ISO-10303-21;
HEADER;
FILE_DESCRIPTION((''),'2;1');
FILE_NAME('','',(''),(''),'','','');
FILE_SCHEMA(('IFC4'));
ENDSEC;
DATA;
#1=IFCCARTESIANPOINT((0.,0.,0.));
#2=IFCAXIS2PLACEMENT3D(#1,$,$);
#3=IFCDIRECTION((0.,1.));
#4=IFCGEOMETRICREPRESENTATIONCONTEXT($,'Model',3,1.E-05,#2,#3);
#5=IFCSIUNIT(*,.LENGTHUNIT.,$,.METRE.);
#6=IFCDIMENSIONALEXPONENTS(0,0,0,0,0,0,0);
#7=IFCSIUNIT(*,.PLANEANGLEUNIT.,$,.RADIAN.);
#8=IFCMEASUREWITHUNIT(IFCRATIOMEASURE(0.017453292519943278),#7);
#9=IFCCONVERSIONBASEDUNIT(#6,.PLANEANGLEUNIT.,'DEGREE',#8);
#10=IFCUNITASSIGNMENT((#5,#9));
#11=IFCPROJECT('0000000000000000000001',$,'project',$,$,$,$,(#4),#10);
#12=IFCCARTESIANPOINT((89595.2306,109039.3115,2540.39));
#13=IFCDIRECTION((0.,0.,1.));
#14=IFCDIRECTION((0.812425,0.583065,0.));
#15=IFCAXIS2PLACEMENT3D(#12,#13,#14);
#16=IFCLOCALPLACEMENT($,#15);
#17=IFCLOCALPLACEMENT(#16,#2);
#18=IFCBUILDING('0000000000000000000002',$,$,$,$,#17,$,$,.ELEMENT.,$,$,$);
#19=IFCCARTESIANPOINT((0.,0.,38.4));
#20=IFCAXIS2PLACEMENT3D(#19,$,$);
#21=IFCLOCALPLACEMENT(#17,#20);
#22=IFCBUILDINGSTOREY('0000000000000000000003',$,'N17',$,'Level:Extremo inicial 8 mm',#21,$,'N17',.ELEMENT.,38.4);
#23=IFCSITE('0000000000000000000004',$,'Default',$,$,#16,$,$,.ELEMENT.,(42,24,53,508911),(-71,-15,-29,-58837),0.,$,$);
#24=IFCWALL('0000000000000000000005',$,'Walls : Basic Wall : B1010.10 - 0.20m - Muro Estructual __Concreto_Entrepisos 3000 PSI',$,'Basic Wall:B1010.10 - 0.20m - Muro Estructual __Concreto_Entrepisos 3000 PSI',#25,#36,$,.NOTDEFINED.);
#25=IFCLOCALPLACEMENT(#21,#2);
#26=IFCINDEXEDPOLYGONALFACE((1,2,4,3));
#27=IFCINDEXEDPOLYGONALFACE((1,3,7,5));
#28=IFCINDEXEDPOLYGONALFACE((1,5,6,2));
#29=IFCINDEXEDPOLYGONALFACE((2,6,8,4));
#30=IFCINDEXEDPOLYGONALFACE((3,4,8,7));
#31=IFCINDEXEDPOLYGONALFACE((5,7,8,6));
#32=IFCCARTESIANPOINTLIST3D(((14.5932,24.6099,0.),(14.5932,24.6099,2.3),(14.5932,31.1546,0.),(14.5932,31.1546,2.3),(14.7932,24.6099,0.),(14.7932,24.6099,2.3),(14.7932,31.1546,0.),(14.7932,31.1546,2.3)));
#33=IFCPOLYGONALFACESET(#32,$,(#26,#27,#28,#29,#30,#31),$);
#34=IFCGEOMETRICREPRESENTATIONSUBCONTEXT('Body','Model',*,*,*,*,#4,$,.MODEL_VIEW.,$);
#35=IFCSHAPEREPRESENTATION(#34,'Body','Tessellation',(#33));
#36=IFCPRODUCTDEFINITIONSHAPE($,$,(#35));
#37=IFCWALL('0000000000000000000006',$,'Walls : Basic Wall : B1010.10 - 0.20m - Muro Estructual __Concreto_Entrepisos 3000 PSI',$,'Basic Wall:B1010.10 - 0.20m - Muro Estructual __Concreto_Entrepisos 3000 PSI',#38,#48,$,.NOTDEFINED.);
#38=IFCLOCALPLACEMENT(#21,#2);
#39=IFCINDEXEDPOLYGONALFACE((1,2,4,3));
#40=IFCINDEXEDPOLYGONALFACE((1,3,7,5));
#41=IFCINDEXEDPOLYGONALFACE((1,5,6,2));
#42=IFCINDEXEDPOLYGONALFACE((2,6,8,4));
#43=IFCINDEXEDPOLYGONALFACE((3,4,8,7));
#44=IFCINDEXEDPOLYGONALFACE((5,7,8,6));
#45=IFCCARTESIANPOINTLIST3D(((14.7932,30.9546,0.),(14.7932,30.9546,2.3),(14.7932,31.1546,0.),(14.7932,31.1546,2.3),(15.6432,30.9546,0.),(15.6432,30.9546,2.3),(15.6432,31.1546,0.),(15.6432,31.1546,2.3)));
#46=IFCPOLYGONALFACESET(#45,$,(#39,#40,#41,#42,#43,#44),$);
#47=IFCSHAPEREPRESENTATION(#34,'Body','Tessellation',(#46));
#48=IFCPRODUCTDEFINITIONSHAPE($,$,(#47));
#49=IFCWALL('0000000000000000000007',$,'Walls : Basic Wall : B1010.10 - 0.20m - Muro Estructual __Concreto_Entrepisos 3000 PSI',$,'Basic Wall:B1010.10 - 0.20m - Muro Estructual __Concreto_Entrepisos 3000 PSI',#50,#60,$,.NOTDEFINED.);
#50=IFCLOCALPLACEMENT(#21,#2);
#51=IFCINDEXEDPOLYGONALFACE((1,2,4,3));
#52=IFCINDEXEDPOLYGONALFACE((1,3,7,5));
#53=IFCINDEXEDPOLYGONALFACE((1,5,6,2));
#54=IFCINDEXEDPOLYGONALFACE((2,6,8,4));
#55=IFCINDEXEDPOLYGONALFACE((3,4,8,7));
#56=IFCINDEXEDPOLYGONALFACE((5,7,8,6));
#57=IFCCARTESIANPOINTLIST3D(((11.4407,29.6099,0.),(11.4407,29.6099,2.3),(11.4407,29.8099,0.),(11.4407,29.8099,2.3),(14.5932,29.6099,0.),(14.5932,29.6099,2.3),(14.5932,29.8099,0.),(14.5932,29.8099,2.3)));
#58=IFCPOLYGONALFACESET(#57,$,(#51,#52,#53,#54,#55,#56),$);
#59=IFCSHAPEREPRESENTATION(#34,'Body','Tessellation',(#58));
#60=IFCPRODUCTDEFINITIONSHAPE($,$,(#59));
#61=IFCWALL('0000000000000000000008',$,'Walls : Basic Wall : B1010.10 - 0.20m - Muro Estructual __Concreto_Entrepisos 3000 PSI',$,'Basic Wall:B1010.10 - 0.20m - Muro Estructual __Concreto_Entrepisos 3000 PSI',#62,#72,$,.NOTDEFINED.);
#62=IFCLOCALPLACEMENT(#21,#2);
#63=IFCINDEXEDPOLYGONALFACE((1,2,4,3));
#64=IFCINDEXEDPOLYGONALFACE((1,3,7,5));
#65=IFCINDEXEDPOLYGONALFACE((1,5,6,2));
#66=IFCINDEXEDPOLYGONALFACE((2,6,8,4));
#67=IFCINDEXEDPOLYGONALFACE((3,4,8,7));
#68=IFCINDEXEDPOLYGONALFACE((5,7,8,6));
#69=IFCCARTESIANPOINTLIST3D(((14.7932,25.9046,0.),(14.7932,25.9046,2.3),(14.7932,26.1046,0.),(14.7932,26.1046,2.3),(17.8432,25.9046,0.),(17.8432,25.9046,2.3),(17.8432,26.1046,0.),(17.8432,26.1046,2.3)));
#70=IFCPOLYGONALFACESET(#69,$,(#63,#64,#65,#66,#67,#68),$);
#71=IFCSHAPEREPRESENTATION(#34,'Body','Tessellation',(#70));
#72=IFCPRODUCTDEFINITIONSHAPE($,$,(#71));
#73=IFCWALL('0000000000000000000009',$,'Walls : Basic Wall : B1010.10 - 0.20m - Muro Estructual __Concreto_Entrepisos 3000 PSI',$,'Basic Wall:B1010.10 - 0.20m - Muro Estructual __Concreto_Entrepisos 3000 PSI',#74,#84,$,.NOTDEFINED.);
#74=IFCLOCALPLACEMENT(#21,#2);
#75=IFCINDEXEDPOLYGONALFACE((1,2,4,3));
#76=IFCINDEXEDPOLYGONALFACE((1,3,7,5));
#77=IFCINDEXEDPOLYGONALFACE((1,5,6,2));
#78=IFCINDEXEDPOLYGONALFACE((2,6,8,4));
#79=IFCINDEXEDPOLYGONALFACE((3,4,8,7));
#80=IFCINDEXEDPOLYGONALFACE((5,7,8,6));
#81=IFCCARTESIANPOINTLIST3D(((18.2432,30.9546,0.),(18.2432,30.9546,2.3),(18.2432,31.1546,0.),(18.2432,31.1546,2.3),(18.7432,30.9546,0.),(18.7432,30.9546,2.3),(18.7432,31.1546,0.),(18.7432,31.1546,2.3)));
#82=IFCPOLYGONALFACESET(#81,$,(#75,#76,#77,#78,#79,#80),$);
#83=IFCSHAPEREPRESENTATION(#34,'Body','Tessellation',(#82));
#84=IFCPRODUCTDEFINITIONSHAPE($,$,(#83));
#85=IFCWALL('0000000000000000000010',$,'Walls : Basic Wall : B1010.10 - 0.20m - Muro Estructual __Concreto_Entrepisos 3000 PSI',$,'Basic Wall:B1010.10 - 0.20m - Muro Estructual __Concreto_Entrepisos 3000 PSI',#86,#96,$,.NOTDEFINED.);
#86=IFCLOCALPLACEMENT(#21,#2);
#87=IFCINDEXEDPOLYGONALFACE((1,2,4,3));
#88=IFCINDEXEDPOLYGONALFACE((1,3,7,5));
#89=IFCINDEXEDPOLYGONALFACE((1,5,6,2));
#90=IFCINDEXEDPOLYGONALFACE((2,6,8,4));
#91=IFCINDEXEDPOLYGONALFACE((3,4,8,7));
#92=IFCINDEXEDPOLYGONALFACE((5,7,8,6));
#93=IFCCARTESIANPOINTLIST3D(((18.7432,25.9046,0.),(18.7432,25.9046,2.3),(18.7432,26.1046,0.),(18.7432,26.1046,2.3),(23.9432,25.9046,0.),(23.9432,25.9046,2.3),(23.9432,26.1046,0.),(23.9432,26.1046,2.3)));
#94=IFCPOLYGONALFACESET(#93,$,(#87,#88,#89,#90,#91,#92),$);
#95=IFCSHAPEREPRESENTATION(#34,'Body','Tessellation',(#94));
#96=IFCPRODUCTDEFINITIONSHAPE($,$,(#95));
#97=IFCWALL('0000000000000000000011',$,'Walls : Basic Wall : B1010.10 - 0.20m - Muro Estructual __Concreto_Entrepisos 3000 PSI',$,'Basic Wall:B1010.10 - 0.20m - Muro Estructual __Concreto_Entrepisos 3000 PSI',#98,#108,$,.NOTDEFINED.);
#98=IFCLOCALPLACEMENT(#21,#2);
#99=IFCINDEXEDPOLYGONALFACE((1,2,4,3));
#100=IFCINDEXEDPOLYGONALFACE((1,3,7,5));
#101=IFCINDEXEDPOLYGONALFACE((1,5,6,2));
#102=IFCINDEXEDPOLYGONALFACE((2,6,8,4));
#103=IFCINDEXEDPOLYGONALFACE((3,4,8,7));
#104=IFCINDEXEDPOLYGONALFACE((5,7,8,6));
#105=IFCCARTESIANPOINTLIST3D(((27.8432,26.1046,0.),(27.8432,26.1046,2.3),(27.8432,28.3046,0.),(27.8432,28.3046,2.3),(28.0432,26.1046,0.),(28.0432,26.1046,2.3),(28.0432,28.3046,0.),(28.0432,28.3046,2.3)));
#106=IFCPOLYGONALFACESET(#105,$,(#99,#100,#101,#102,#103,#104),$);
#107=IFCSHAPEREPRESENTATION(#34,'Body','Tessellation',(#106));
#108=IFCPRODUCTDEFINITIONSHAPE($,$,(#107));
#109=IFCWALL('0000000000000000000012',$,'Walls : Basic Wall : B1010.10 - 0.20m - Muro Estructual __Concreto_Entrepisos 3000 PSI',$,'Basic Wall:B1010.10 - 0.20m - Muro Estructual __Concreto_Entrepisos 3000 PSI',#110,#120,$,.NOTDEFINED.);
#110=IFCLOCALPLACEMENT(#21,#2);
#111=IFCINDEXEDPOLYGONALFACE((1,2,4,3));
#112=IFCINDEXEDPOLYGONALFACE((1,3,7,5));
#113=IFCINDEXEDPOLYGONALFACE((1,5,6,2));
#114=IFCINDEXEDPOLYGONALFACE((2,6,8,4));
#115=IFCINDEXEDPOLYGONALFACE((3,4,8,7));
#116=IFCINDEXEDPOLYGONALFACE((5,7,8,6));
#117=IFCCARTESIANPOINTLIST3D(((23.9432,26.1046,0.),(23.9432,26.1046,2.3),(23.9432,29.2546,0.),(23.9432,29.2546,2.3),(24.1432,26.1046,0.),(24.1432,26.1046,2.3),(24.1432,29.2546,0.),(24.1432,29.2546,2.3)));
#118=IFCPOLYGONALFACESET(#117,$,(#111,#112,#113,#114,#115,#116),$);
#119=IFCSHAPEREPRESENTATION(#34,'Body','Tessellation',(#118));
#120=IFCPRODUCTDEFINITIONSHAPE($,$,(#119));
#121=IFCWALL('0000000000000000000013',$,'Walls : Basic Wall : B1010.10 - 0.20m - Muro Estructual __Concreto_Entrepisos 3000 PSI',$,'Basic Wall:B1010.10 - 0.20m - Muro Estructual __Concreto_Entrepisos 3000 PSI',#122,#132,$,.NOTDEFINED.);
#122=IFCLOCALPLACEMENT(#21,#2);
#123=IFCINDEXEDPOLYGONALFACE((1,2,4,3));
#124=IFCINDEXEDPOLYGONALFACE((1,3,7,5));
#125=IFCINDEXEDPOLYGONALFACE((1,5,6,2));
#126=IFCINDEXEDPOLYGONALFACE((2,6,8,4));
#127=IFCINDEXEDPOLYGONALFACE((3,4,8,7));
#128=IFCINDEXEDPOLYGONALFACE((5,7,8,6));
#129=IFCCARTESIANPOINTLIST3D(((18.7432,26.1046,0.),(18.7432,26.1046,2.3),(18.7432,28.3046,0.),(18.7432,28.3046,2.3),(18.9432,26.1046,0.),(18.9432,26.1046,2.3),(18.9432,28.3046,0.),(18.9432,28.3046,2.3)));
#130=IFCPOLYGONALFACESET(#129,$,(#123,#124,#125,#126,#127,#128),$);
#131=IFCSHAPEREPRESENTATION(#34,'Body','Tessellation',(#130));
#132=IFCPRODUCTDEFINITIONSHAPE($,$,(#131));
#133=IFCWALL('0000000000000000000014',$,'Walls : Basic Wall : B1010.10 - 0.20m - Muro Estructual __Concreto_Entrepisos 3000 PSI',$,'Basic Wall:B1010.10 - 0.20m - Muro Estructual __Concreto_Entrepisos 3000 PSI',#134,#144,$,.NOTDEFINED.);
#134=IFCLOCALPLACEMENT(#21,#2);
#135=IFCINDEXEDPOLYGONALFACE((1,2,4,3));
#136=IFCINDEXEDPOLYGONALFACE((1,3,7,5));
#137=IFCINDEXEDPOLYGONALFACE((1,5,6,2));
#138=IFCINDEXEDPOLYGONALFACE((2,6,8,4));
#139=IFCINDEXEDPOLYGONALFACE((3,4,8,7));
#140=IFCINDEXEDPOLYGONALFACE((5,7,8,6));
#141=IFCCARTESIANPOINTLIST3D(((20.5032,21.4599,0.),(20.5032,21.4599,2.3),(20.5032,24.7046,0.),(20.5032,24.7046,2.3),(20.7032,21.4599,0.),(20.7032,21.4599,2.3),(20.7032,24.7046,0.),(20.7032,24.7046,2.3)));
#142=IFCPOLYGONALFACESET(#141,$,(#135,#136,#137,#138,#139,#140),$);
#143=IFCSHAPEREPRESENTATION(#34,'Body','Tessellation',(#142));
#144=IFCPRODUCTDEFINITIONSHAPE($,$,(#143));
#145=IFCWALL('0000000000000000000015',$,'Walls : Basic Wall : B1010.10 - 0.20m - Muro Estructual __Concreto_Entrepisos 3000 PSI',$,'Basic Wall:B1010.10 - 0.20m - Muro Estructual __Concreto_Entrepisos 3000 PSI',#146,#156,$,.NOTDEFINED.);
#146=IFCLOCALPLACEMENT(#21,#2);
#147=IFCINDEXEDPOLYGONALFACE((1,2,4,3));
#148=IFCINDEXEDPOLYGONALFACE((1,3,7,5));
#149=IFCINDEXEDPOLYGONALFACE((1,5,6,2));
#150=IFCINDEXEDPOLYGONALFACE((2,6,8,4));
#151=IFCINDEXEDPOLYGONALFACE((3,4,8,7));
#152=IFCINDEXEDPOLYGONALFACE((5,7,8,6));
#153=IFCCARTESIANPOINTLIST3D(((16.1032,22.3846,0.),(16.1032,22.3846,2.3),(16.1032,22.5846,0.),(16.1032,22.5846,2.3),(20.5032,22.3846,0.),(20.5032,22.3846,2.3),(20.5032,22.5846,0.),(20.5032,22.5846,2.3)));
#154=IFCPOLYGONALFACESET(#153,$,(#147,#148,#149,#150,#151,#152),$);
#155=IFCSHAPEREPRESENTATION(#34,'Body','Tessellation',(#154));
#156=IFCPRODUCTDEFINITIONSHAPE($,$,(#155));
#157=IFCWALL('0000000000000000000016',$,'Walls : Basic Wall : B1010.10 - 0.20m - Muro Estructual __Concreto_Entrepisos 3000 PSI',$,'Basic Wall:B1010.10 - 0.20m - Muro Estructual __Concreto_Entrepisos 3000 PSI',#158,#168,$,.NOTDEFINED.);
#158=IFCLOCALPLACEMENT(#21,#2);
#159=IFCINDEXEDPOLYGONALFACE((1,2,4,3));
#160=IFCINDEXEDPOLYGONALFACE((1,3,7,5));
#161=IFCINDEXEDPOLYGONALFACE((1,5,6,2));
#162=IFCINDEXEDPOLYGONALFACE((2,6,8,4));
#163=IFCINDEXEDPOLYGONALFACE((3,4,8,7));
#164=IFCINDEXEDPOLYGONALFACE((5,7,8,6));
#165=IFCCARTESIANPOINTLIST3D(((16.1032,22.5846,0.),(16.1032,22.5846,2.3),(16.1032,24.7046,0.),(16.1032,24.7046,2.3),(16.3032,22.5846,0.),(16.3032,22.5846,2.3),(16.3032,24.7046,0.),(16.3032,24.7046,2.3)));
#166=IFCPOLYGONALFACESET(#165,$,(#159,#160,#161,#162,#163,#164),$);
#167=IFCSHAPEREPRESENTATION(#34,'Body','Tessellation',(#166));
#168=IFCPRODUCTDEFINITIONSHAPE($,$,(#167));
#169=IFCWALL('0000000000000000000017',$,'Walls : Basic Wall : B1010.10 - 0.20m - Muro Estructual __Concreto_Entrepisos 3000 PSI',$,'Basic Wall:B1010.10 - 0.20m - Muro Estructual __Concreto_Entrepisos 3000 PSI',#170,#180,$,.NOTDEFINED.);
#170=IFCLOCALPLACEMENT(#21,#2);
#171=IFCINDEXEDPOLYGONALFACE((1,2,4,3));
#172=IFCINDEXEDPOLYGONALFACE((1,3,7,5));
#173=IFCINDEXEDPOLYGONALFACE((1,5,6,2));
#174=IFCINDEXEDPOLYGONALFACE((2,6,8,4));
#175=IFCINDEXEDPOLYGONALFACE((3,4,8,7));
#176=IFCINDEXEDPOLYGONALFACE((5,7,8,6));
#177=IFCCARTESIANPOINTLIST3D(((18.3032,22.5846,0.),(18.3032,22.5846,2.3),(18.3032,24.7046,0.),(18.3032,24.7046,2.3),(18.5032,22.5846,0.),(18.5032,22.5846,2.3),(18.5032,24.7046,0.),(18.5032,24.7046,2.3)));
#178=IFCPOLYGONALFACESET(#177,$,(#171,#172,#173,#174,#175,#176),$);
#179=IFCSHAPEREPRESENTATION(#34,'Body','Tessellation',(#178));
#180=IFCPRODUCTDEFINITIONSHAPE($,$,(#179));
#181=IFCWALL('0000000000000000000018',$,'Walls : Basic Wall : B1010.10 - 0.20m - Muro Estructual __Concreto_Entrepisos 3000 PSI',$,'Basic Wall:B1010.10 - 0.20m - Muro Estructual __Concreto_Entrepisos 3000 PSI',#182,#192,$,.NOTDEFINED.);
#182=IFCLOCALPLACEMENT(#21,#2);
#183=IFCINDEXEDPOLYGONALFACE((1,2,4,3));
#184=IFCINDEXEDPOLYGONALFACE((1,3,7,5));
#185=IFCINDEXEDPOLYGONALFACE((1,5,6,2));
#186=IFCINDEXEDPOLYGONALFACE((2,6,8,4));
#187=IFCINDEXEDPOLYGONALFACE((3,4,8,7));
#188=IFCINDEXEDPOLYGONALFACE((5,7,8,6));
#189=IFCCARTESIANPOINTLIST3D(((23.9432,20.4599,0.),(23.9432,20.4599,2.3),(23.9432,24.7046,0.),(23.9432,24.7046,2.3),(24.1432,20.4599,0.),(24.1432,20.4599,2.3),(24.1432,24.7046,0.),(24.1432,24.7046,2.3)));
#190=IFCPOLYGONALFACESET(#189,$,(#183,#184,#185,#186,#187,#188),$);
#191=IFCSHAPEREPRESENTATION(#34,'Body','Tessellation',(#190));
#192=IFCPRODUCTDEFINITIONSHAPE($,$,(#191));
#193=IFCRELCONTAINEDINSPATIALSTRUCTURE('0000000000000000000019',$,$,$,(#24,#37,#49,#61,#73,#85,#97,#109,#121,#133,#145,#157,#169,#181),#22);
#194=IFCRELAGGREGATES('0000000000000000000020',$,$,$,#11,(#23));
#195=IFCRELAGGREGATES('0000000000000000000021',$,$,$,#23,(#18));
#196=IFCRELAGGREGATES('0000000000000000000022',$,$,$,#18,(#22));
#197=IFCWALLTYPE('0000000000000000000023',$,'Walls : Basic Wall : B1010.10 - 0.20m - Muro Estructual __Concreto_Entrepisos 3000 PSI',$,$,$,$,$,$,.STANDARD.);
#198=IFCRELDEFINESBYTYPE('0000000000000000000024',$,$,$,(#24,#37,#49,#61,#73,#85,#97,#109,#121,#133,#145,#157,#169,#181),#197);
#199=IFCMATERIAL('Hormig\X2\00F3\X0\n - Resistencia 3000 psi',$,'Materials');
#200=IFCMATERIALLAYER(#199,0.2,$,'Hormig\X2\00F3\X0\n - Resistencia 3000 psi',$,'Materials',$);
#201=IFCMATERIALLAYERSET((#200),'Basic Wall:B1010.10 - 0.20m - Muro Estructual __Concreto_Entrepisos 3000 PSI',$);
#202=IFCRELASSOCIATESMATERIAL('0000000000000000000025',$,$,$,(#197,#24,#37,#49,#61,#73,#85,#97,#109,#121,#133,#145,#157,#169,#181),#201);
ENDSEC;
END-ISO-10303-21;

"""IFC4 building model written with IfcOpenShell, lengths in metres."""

from ifc_helpers import new_model, entity, si_unit, converted_unit, direction, frame, frame_2d, origin, place, context, subcontext, project, spatial, rectangle, extrude, material, layer, layer_set, layer_usage, type_object, element, save


model = new_model("IFC4")

# Units and contexts
model_context = context("Model", 3, precision=1e-05, world=origin(), true_north=direction((0.0, 1.0)))
body_context = subcontext(model_context, "Body", "Model", "MODEL_VIEW")
ifc_project = project(units=[si_unit("LENGTHUNIT", "METRE"), converted_unit("PLANEANGLEUNIT", "DEGREE", entity("IfcRatioMeasure", 0.017453292519943278), si_unit("PLANEANGLEUNIT", "RADIAN"), dimensions=[0, 0, 0, 0, 0, 0, 0])], contexts=[model_context])

# Site, building, storey
site_placement = place(None, frame((89595.2306, 109039.3115, 2540.39), z_axis=(0.0, 0.0, 1.0), x_axis=(0.812425, 0.583065, 0.0)))
site = spatial("IfcSite", under=ifc_project, at=site_placement, Name="Default", CompositionType="ELEMENT", RefLatitude=(42, 24, 53, 508911), RefLongitude=(-71, -15, -29, -58837), RefElevation=0.0)
building_placement = place(site_placement, origin())
building = spatial("IfcBuilding", under=site, at=building_placement, CompositionType="ELEMENT")
storey_placement = place(building_placement, frame((0.0, 0.0, 38.4)))
storey = spatial("IfcBuildingStorey", under=building, at=storey_placement, Name="N17", ObjectType="Level:Extremo inicial 8 mm", LongName="N17", CompositionType="ELEMENT", Elevation=38.4)

# Walls
ifc_material_1 = material(Name="Hormigón - Resistencia 3000 psi", Category="Materials")
ifc_layer_1 = layer(ifc_material_1, 0.2, Name="Hormigón - Resistencia 3000 psi", Category="Materials")
ifc_layer_set_1 = layer_set([ifc_layer_1], Name="Basic Wall:B1010.10 - 0.20m - Muro Estructual __Concreto_Entrepisos 3000 PSI")
ifc_layer_usage_1 = layer_usage(ifc_layer_set_1, "AXIS2", "NEGATIVE", 0.1)
wall_type_1 = type_object("IfcWallType", Name="Walls : Basic Wall : B1010.10 - 0.20m - Muro Estructual __Concreto_Entrepisos 3000 PSI", PredefinedType="STANDARD", material=ifc_layer_set_1)
wall_1_placement = place(storey_placement, frame((14.6932, 24.6099, 0.0), z_axis=(0.0, 0.0, 1.0), x_axis=(0.0, 1.0, 0.0)))
element("IfcWall", 1, at=wall_1_placement, inside=storey, type_object=wall_type_1, material=ifc_layer_usage_1, Name="Walls : Basic Wall : B1010.10 - 0.20m - Muro Estructual __Concreto_Entrepisos 3000 PSI", ObjectType="Basic Wall:B1010.10 - 0.20m - Muro Estructual __Concreto_Entrepisos 3000 PSI", PredefinedType="NOTDEFINED", context=body_context, shape_type="SweptSolid", body=[
    extrude(rectangle(XDim=6.5447, YDim=0.2, at=frame_2d((3.2724, 0.0), x_axis=(-1.0, 0.0))), origin(), (0.0, 0.0, 1.0), 2.3),
])
ifc_layer_usage_2 = layer_usage(ifc_layer_set_1, "AXIS2", "NEGATIVE", 0.1)
wall_2_placement = place(storey_placement, frame((15.6432, 31.0546, 0.0), z_axis=(0.0, 0.0, 1.0), x_axis=(-1.0, 0.0, 0.0)))
element("IfcWall", 2, at=wall_2_placement, inside=storey, type_object=wall_type_1, material=ifc_layer_usage_2, Name="Walls : Basic Wall : B1010.10 - 0.20m - Muro Estructual __Concreto_Entrepisos 3000 PSI", ObjectType="Basic Wall:B1010.10 - 0.20m - Muro Estructual __Concreto_Entrepisos 3000 PSI", PredefinedType="NOTDEFINED", context=body_context, shape_type="SweptSolid", body=[
    extrude(rectangle(XDim=0.85, YDim=0.2, at=frame_2d((0.425, 0.0), x_axis=(-1.0, 0.0))), origin(), (0.0, 0.0, 1.0), 2.3),
])
ifc_layer_usage_3 = layer_usage(ifc_layer_set_1, "AXIS2", "NEGATIVE", 0.1)
wall_3_placement = place(storey_placement, frame((11.4407, 29.7099, 0.0)))
element("IfcWall", 3, at=wall_3_placement, inside=storey, type_object=wall_type_1, material=ifc_layer_usage_3, Name="Walls : Basic Wall : B1010.10 - 0.20m - Muro Estructual __Concreto_Entrepisos 3000 PSI", ObjectType="Basic Wall:B1010.10 - 0.20m - Muro Estructual __Concreto_Entrepisos 3000 PSI", PredefinedType="NOTDEFINED", context=body_context, shape_type="SweptSolid", body=[
    extrude(rectangle(XDim=3.1525, YDim=0.2, at=frame_2d((1.5763, 0.0), x_axis=(-1.0, 0.0))), origin(), (0.0, 0.0, 1.0), 2.3),
])
ifc_layer_usage_4 = layer_usage(ifc_layer_set_1, "AXIS2", "NEGATIVE", 0.1)
wall_4_placement = place(storey_placement, frame((17.8432, 26.0046, 0.0), z_axis=(0.0, 0.0, 1.0), x_axis=(-1.0, 0.0, 0.0)))
element("IfcWall", 4, at=wall_4_placement, inside=storey, type_object=wall_type_1, material=ifc_layer_usage_4, Name="Walls : Basic Wall : B1010.10 - 0.20m - Muro Estructual __Concreto_Entrepisos 3000 PSI", ObjectType="Basic Wall:B1010.10 - 0.20m - Muro Estructual __Concreto_Entrepisos 3000 PSI", PredefinedType="NOTDEFINED", context=body_context, shape_type="SweptSolid", body=[
    extrude(rectangle(XDim=3.05, YDim=0.2, at=frame_2d((1.525, 0.0), x_axis=(-1.0, 0.0))), origin(), (0.0, 0.0, 1.0), 2.3),
])
ifc_layer_usage_5 = layer_usage(ifc_layer_set_1, "AXIS2", "NEGATIVE", 0.1)
wall_5_placement = place(storey_placement, frame((18.7432, 31.0546, 0.0), z_axis=(0.0, 0.0, 1.0), x_axis=(-1.0, 0.0, 0.0)))
element("IfcWall", 5, at=wall_5_placement, inside=storey, type_object=wall_type_1, material=ifc_layer_usage_5, Name="Walls : Basic Wall : B1010.10 - 0.20m - Muro Estructual __Concreto_Entrepisos 3000 PSI", ObjectType="Basic Wall:B1010.10 - 0.20m - Muro Estructual __Concreto_Entrepisos 3000 PSI", PredefinedType="NOTDEFINED", context=body_context, shape_type="SweptSolid", body=[
    extrude(rectangle(XDim=0.5, YDim=0.2, at=frame_2d((0.25, 0.0), x_axis=(-1.0, 0.0))), origin(), (0.0, 0.0, 1.0), 2.3),
])
ifc_layer_usage_6 = layer_usage(ifc_layer_set_1, "AXIS2", "NEGATIVE", 0.1)
wall_6_placement = place(storey_placement, frame((18.7432, 26.0046, 0.0)))
element("IfcWall", 6, at=wall_6_placement, inside=storey, type_object=wall_type_1, material=ifc_layer_usage_6, Name="Walls : Basic Wall : B1010.10 - 0.20m - Muro Estructual __Concreto_Entrepisos 3000 PSI", ObjectType="Basic Wall:B1010.10 - 0.20m - Muro Estructual __Concreto_Entrepisos 3000 PSI", PredefinedType="NOTDEFINED", context=body_context, shape_type="SweptSolid", body=[
    extrude(rectangle(XDim=5.2, YDim=0.2, at=frame_2d((2.6, 0.0), x_axis=(-1.0, 0.0))), origin(), (0.0, 0.0, 1.0), 2.3),
])
ifc_layer_usage_7 = layer_usage(ifc_layer_set_1, "AXIS2", "NEGATIVE", 0.1)
wall_7_placement = place(storey_placement, frame((27.9432, 28.3046, 0.0), z_axis=(0.0, 0.0, 1.0), x_axis=(0.0, -1.0, 0.0)))
element("IfcWall", 7, at=wall_7_placement, inside=storey, type_object=wall_type_1, material=ifc_layer_usage_7, Name="Walls : Basic Wall : B1010.10 - 0.20m - Muro Estructual __Concreto_Entrepisos 3000 PSI", ObjectType="Basic Wall:B1010.10 - 0.20m - Muro Estructual __Concreto_Entrepisos 3000 PSI", PredefinedType="NOTDEFINED", context=body_context, shape_type="SweptSolid", body=[
    extrude(rectangle(XDim=2.2, YDim=0.2, at=frame_2d((1.1, 0.0), x_axis=(-1.0, 0.0))), origin(), (0.0, 0.0, 1.0), 2.3),
])
ifc_layer_usage_8 = layer_usage(ifc_layer_set_1, "AXIS2", "NEGATIVE", 0.1)
wall_8_placement = place(storey_placement, frame((24.0432, 26.1046, 0.0), z_axis=(0.0, 0.0, 1.0), x_axis=(0.0, 1.0, 0.0)))
element("IfcWall", 8, at=wall_8_placement, inside=storey, type_object=wall_type_1, material=ifc_layer_usage_8, Name="Walls : Basic Wall : B1010.10 - 0.20m - Muro Estructual __Concreto_Entrepisos 3000 PSI", ObjectType="Basic Wall:B1010.10 - 0.20m - Muro Estructual __Concreto_Entrepisos 3000 PSI", PredefinedType="NOTDEFINED", context=body_context, shape_type="SweptSolid", body=[
    extrude(rectangle(XDim=3.15, YDim=0.2, at=frame_2d((1.575, 0.0), x_axis=(-1.0, 0.0))), origin(), (0.0, 0.0, 1.0), 2.3),
])
ifc_layer_usage_9 = layer_usage(ifc_layer_set_1, "AXIS2", "NEGATIVE", 0.1)
wall_9_placement = place(storey_placement, frame((18.8432, 28.3046, 0.0), z_axis=(0.0, 0.0, 1.0), x_axis=(0.0, -1.0, 0.0)))
element("IfcWall", 9, at=wall_9_placement, inside=storey, type_object=wall_type_1, material=ifc_layer_usage_9, Name="Walls : Basic Wall : B1010.10 - 0.20m - Muro Estructual __Concreto_Entrepisos 3000 PSI", ObjectType="Basic Wall:B1010.10 - 0.20m - Muro Estructual __Concreto_Entrepisos 3000 PSI", PredefinedType="NOTDEFINED", context=body_context, shape_type="SweptSolid", body=[
    extrude(rectangle(XDim=2.2, YDim=0.2, at=frame_2d((1.1, 0.0), x_axis=(-1.0, 0.0))), origin(), (0.0, 0.0, 1.0), 2.3),
])
ifc_layer_usage_10 = layer_usage(ifc_layer_set_1, "AXIS2", "NEGATIVE", 0.1)
wall_10_placement = place(storey_placement, frame((20.6032, 21.4599, 0.0), z_axis=(0.0, 0.0, 1.0), x_axis=(0.0, 1.0, 0.0)))
element("IfcWall", 10, at=wall_10_placement, inside=storey, type_object=wall_type_1, material=ifc_layer_usage_10, Name="Walls : Basic Wall : B1010.10 - 0.20m - Muro Estructual __Concreto_Entrepisos 3000 PSI", ObjectType="Basic Wall:B1010.10 - 0.20m - Muro Estructual __Concreto_Entrepisos 3000 PSI", PredefinedType="NOTDEFINED", context=body_context, shape_type="SweptSolid", body=[
    extrude(rectangle(XDim=3.2447, YDim=0.2, at=frame_2d((1.6224, 0.0), x_axis=(-1.0, 0.0))), origin(), (0.0, 0.0, 1.0), 2.3),
])
ifc_layer_usage_11 = layer_usage(ifc_layer_set_1, "AXIS2", "NEGATIVE", 0.1)
wall_11_placement = place(storey_placement, frame((20.5032, 22.4846, 0.0), z_axis=(0.0, 0.0, 1.0), x_axis=(-1.0, 0.0, 0.0)))
element("IfcWall", 11, at=wall_11_placement, inside=storey, type_object=wall_type_1, material=ifc_layer_usage_11, Name="Walls : Basic Wall : B1010.10 - 0.20m - Muro Estructual __Concreto_Entrepisos 3000 PSI", ObjectType="Basic Wall:B1010.10 - 0.20m - Muro Estructual __Concreto_Entrepisos 3000 PSI", PredefinedType="NOTDEFINED", context=body_context, shape_type="SweptSolid", body=[
    extrude(rectangle(XDim=4.4, YDim=0.2, at=frame_2d((2.2, 0.0), x_axis=(-1.0, 0.0))), origin(), (0.0, 0.0, 1.0), 2.3),
])
ifc_layer_usage_12 = layer_usage(ifc_layer_set_1, "AXIS2", "NEGATIVE", 0.1)
wall_12_placement = place(storey_placement, frame((16.2032, 22.5846, 0.0), z_axis=(0.0, 0.0, 1.0), x_axis=(0.0, 1.0, 0.0)))
element("IfcWall", 12, at=wall_12_placement, inside=storey, type_object=wall_type_1, material=ifc_layer_usage_12, Name="Walls : Basic Wall : B1010.10 - 0.20m - Muro Estructual __Concreto_Entrepisos 3000 PSI", ObjectType="Basic Wall:B1010.10 - 0.20m - Muro Estructual __Concreto_Entrepisos 3000 PSI", PredefinedType="NOTDEFINED", context=body_context, shape_type="SweptSolid", body=[
    extrude(rectangle(XDim=2.12, YDim=0.2, at=frame_2d((1.06, 0.0), x_axis=(-1.0, 0.0))), origin(), (0.0, 0.0, 1.0), 2.3),
])
ifc_layer_usage_13 = layer_usage(ifc_layer_set_1, "AXIS2", "NEGATIVE", 0.1)
wall_13_placement = place(storey_placement, frame((18.4032, 24.7046, 0.0), z_axis=(0.0, 0.0, 1.0), x_axis=(0.0, -1.0, 0.0)))
element("IfcWall", 13, at=wall_13_placement, inside=storey, type_object=wall_type_1, material=ifc_layer_usage_13, Name="Walls : Basic Wall : B1010.10 - 0.20m - Muro Estructual __Concreto_Entrepisos 3000 PSI", ObjectType="Basic Wall:B1010.10 - 0.20m - Muro Estructual __Concreto_Entrepisos 3000 PSI", PredefinedType="NOTDEFINED", context=body_context, shape_type="SweptSolid", body=[
    extrude(rectangle(XDim=2.12, YDim=0.2, at=frame_2d((1.06, 0.0), x_axis=(-1.0, 0.0))), origin(), (0.0, 0.0, 1.0), 2.3),
])
ifc_layer_usage_14 = layer_usage(ifc_layer_set_1, "AXIS2", "NEGATIVE", 0.1)
wall_14_placement = place(storey_placement, frame((24.0432, 20.4599, 0.0), z_axis=(0.0, 0.0, 1.0), x_axis=(0.0, 1.0, 0.0)))
element("IfcWall", 14, at=wall_14_placement, inside=storey, type_object=wall_type_1, material=ifc_layer_usage_14, Name="Walls : Basic Wall : B1010.10 - 0.20m - Muro Estructual __Concreto_Entrepisos 3000 PSI", ObjectType="Basic Wall:B1010.10 - 0.20m - Muro Estructual __Concreto_Entrepisos 3000 PSI", PredefinedType="NOTDEFINED", context=body_context, shape_type="SweptSolid", body=[
    extrude(rectangle(XDim=4.2447, YDim=0.2, at=frame_2d((2.1224, 0.0), x_axis=(-1.0, 0.0))), origin(), (0.0, 0.0, 1.0), 2.3),
])

save(model, "model.ifc")
